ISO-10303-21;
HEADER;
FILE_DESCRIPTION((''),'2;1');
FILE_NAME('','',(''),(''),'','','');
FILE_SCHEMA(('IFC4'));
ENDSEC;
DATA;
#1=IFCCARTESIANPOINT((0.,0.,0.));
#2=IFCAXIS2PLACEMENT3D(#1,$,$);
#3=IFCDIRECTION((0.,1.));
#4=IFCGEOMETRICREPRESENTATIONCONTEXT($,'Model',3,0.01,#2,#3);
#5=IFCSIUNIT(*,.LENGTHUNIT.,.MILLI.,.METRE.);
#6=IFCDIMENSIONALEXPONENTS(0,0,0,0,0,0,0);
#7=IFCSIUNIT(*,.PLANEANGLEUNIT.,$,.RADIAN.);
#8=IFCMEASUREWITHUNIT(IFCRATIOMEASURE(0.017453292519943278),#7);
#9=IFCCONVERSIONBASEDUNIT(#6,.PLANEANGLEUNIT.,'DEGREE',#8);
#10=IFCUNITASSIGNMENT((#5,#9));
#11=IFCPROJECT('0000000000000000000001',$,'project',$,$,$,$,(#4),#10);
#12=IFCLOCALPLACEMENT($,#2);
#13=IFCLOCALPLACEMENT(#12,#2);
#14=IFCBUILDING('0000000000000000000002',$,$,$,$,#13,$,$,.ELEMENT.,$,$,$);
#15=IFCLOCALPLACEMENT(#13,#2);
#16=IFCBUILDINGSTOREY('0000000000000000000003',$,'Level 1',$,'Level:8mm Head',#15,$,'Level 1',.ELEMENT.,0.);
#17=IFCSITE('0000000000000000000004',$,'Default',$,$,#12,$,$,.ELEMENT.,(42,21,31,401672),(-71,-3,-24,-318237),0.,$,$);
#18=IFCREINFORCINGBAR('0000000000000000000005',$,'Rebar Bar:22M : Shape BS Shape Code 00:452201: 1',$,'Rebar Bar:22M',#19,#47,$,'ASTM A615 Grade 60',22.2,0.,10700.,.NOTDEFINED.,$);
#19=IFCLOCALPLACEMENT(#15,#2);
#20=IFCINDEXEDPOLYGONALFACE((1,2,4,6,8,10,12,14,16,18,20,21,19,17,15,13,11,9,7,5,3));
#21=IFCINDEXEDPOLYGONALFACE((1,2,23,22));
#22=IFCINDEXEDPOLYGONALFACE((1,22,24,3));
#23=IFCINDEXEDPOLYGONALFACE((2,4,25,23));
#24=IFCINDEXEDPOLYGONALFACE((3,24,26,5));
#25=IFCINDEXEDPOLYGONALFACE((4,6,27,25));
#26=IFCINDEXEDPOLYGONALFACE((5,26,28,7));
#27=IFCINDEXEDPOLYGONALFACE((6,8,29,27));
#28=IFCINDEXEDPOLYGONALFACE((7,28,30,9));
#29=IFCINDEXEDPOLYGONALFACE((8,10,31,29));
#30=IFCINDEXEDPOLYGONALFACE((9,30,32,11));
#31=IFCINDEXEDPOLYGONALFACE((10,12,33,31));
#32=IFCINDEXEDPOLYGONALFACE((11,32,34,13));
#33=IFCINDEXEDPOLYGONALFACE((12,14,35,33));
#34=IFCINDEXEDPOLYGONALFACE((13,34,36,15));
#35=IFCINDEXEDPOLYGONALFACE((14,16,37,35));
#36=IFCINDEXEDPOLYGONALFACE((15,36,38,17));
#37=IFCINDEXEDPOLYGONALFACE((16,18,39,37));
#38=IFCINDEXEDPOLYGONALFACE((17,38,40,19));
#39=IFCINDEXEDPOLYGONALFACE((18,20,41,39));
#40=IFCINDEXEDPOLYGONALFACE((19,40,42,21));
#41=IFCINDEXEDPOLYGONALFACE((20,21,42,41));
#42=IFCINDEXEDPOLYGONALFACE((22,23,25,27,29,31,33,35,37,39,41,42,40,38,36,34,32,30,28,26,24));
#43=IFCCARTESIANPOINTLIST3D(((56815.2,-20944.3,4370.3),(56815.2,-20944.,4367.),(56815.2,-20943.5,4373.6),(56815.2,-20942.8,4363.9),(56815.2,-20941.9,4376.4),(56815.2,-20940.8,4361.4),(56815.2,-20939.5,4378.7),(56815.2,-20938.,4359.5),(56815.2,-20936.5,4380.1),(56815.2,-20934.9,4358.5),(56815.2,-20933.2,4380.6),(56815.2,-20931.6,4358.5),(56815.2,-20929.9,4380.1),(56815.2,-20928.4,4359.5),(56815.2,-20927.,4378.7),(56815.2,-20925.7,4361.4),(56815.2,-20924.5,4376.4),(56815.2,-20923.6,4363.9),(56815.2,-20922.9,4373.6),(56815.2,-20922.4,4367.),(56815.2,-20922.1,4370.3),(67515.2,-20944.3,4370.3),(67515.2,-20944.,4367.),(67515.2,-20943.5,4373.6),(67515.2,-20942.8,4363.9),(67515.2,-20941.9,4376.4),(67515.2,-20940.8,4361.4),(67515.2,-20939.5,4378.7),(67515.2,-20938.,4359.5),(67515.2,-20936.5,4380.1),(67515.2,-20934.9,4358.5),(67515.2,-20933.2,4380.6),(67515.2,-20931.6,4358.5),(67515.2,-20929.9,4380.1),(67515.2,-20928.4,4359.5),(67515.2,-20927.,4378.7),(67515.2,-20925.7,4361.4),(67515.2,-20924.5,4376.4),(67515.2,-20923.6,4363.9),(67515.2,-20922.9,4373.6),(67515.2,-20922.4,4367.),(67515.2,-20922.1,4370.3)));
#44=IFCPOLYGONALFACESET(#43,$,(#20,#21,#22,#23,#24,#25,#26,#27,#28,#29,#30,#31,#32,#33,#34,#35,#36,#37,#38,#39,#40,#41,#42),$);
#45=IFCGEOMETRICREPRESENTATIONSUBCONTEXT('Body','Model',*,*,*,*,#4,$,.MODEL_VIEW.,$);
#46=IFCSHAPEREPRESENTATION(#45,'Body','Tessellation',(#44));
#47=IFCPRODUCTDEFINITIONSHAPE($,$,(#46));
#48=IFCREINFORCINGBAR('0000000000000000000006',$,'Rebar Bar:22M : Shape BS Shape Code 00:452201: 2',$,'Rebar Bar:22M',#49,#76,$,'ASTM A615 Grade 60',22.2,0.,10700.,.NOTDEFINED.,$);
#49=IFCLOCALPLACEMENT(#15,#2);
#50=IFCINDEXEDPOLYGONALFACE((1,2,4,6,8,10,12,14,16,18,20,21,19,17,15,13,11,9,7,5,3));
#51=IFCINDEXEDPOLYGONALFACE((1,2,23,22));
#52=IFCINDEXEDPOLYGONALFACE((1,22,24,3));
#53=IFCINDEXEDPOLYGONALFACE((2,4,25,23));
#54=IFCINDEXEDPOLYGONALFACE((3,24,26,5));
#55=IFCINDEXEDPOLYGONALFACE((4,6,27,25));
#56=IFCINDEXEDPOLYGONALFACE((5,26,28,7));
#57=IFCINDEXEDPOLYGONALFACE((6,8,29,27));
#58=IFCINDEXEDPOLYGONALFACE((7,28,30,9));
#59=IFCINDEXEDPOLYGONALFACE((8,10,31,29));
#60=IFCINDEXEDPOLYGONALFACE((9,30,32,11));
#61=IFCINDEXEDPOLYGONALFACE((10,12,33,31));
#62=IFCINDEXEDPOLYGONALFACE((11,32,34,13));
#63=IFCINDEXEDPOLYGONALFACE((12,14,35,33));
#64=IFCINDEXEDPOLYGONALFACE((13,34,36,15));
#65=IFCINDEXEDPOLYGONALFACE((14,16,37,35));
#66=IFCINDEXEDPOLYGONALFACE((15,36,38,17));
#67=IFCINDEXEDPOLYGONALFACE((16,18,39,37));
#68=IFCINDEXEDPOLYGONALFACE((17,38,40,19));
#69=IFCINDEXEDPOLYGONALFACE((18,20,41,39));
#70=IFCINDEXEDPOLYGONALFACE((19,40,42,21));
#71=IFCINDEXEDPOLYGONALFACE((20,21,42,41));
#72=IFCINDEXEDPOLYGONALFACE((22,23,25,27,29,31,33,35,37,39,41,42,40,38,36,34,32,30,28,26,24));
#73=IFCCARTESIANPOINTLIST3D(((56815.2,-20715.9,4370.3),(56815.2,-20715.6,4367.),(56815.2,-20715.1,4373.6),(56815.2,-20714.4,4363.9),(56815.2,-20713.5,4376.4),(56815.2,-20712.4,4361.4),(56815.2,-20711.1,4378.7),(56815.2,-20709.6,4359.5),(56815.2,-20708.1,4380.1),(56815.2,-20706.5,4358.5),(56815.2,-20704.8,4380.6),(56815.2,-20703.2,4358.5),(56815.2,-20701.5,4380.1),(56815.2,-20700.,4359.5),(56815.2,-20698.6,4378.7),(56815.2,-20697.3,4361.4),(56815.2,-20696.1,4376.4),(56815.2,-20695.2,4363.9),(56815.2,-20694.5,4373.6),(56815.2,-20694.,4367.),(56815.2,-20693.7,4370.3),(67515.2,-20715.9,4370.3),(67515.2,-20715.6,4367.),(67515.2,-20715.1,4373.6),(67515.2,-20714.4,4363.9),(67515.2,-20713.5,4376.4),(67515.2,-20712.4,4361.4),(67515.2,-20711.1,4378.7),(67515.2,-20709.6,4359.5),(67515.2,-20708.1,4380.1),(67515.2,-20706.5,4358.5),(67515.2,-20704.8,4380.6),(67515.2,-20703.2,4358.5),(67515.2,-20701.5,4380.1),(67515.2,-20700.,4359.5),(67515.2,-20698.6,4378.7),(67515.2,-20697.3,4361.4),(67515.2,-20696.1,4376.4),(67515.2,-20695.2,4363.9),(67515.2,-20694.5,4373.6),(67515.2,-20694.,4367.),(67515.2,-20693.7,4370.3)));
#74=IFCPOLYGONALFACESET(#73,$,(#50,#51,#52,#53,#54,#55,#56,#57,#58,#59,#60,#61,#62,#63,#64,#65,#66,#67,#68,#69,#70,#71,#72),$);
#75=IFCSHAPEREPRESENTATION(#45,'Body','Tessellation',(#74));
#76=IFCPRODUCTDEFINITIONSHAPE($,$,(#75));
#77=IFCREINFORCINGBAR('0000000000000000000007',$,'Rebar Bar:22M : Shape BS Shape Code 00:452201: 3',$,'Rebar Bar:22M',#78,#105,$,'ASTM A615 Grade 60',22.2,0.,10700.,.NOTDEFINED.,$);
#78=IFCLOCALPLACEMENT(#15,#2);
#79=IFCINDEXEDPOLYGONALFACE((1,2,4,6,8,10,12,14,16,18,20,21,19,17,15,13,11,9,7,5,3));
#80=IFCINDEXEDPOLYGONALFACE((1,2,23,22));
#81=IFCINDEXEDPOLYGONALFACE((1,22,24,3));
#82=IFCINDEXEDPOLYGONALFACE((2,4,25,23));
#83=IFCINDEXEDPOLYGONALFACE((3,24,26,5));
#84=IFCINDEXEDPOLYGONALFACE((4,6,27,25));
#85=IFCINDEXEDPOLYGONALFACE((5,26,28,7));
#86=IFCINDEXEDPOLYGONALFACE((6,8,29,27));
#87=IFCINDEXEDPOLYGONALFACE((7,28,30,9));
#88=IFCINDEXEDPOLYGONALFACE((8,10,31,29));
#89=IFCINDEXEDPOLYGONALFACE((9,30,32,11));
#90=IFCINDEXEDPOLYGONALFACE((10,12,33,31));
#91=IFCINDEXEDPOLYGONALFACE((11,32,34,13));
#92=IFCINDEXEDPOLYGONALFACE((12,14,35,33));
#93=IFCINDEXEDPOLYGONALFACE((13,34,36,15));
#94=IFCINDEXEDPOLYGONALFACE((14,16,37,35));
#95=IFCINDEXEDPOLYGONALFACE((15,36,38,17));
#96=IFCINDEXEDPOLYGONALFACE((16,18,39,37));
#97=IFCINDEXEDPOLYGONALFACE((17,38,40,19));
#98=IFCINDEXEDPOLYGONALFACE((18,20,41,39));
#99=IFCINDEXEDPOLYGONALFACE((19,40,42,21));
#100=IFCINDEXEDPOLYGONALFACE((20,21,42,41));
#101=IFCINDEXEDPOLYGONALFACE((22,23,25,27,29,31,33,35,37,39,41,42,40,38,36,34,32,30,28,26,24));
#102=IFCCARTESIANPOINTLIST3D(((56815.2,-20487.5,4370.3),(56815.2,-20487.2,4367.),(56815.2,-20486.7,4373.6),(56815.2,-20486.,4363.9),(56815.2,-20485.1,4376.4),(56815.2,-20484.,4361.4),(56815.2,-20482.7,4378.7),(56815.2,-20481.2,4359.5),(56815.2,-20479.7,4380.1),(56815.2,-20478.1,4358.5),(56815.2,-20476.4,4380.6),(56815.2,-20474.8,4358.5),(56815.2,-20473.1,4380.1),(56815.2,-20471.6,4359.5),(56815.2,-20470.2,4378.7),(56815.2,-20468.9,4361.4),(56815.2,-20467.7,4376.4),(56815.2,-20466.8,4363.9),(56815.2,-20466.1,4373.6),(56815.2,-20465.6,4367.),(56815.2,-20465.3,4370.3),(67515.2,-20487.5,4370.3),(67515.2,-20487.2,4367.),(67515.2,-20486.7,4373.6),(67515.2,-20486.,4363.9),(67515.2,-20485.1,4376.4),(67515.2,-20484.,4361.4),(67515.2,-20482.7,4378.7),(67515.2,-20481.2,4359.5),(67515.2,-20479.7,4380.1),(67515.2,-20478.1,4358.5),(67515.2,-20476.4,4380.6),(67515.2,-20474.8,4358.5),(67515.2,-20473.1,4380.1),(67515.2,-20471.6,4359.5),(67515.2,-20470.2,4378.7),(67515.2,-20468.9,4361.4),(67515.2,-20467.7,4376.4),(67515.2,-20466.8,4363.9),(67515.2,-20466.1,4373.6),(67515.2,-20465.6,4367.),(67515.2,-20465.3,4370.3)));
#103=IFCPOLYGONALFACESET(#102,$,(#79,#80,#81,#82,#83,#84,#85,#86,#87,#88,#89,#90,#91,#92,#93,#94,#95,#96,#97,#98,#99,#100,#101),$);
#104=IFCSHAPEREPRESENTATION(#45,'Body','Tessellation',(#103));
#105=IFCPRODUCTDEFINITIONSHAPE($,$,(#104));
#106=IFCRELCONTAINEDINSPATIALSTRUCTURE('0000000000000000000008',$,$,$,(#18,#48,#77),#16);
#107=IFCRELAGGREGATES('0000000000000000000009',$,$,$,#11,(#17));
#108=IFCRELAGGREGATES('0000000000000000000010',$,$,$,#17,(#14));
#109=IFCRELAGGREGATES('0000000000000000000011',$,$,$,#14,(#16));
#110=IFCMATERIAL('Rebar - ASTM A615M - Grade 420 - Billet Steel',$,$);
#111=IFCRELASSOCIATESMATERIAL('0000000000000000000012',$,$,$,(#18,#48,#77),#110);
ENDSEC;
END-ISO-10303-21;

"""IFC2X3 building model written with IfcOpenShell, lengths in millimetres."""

from ifc_helpers import new_model, entity, si_unit, converted_unit, direction, origin, place, context, subcontext, project, spatial, material, element, save


model = new_model("IFC2X3")

# Units and contexts
model_context = context("Model", 3, precision=0.01, world=origin(), true_north=direction((0.0, 1.0)))
body_context = subcontext(model_context, "Body", "Model", "MODEL_VIEW")
ifc_project = project(units=[si_unit("LENGTHUNIT", "METRE", prefix="MILLI"), converted_unit("PLANEANGLEUNIT", "DEGREE", entity("IfcRatioMeasure", 0.017453292519943278), si_unit("PLANEANGLEUNIT", "RADIAN"), dimensions=[0, 0, 0, 0, 0, 0, 0])], contexts=[model_context])

# Site, building, storey
site_placement = place(None, origin())
site = spatial("IfcSite", under=ifc_project, at=site_placement, Name="Default", CompositionType="ELEMENT", RefLatitude=(42, 21, 31, 401672), RefLongitude=(-71, -3, -24, -318237), RefElevation=0.0)
building_placement = place(site_placement, origin())
building = spatial("IfcBuilding", under=site, at=building_placement, CompositionType="ELEMENT")
storey_placement = place(building_placement, origin())
storey = spatial("IfcBuildingStorey", under=building, at=storey_placement, Name="Level 1", ObjectType="Level:8mm Head", LongName="Level 1", CompositionType="ELEMENT", Elevation=0.0)

# Reinforcing bars
ifc_material = material(Name="Rebar - ASTM A615M - Grade 420 - Billet Steel")
reinforcing_bar_1_placement = place(storey_placement, origin())
element("IfcReinforcingBar", 1, at=reinforcing_bar_1_placement, inside=storey, material=ifc_material, Name="Rebar Bar:22M : Shape BS Shape Code 00:452201: 1", SteelGrade="ASTM A615 Grade 60", ObjectType="Rebar Bar:22M", BarLength=10700.0, BarRole="NOTDEFINED", CrossSectionArea=0.0, NominalDiameter=22.2, context=body_context, shape_type="AdvancedSweptSolid", body=[
    entity("IfcSweptDiskSolid", entity("IfcCompositeCurve", [entity("IfcCompositeCurveSegment", "CONTINUOUS", True, entity("IfcPolyline", [entity("IfcCartesianPoint", [56815.2, -20933.2, 4369.5]), entity("IfcCartesianPoint", [67515.2, -20933.2, 4369.5])]))], False), 11.1, None, 0.0, 1.0),
])
reinforcing_bar_2_placement = place(storey_placement, origin())
element("IfcReinforcingBar", 2, at=reinforcing_bar_2_placement, inside=storey, material=ifc_material, Name="Rebar Bar:22M : Shape BS Shape Code 00:452201: 2", SteelGrade="ASTM A615 Grade 60", ObjectType="Rebar Bar:22M", BarLength=10700.0, BarRole="NOTDEFINED", CrossSectionArea=0.0, NominalDiameter=22.2, context=body_context, shape_type="AdvancedSweptSolid", body=[
    entity("IfcSweptDiskSolid", entity("IfcCompositeCurve", [entity("IfcCompositeCurveSegment", "CONTINUOUS", True, entity("IfcPolyline", [entity("IfcCartesianPoint", [56815.2, -20704.8, 4369.5]), entity("IfcCartesianPoint", [67515.2, -20704.8, 4369.5])]))], False), 11.1, None, 0.0, 1.0),
])
reinforcing_bar_3_placement = place(storey_placement, origin())
element("IfcReinforcingBar", 3, at=reinforcing_bar_3_placement, inside=storey, material=ifc_material, Name="Rebar Bar:22M : Shape BS Shape Code 00:452201: 3", SteelGrade="ASTM A615 Grade 60", ObjectType="Rebar Bar:22M", BarLength=10700.0, BarRole="NOTDEFINED", CrossSectionArea=0.0, NominalDiameter=22.2, context=body_context, shape_type="AdvancedSweptSolid", body=[
    entity("IfcSweptDiskSolid", entity("IfcCompositeCurve", [entity("IfcCompositeCurveSegment", "CONTINUOUS", True, entity("IfcPolyline", [entity("IfcCartesianPoint", [56815.2, -20476.4, 4369.5]), entity("IfcCartesianPoint", [67515.2, -20476.4, 4369.5])]))], False), 11.1, None, 0.0, 1.0),
])

save(model, "model.ifc")
